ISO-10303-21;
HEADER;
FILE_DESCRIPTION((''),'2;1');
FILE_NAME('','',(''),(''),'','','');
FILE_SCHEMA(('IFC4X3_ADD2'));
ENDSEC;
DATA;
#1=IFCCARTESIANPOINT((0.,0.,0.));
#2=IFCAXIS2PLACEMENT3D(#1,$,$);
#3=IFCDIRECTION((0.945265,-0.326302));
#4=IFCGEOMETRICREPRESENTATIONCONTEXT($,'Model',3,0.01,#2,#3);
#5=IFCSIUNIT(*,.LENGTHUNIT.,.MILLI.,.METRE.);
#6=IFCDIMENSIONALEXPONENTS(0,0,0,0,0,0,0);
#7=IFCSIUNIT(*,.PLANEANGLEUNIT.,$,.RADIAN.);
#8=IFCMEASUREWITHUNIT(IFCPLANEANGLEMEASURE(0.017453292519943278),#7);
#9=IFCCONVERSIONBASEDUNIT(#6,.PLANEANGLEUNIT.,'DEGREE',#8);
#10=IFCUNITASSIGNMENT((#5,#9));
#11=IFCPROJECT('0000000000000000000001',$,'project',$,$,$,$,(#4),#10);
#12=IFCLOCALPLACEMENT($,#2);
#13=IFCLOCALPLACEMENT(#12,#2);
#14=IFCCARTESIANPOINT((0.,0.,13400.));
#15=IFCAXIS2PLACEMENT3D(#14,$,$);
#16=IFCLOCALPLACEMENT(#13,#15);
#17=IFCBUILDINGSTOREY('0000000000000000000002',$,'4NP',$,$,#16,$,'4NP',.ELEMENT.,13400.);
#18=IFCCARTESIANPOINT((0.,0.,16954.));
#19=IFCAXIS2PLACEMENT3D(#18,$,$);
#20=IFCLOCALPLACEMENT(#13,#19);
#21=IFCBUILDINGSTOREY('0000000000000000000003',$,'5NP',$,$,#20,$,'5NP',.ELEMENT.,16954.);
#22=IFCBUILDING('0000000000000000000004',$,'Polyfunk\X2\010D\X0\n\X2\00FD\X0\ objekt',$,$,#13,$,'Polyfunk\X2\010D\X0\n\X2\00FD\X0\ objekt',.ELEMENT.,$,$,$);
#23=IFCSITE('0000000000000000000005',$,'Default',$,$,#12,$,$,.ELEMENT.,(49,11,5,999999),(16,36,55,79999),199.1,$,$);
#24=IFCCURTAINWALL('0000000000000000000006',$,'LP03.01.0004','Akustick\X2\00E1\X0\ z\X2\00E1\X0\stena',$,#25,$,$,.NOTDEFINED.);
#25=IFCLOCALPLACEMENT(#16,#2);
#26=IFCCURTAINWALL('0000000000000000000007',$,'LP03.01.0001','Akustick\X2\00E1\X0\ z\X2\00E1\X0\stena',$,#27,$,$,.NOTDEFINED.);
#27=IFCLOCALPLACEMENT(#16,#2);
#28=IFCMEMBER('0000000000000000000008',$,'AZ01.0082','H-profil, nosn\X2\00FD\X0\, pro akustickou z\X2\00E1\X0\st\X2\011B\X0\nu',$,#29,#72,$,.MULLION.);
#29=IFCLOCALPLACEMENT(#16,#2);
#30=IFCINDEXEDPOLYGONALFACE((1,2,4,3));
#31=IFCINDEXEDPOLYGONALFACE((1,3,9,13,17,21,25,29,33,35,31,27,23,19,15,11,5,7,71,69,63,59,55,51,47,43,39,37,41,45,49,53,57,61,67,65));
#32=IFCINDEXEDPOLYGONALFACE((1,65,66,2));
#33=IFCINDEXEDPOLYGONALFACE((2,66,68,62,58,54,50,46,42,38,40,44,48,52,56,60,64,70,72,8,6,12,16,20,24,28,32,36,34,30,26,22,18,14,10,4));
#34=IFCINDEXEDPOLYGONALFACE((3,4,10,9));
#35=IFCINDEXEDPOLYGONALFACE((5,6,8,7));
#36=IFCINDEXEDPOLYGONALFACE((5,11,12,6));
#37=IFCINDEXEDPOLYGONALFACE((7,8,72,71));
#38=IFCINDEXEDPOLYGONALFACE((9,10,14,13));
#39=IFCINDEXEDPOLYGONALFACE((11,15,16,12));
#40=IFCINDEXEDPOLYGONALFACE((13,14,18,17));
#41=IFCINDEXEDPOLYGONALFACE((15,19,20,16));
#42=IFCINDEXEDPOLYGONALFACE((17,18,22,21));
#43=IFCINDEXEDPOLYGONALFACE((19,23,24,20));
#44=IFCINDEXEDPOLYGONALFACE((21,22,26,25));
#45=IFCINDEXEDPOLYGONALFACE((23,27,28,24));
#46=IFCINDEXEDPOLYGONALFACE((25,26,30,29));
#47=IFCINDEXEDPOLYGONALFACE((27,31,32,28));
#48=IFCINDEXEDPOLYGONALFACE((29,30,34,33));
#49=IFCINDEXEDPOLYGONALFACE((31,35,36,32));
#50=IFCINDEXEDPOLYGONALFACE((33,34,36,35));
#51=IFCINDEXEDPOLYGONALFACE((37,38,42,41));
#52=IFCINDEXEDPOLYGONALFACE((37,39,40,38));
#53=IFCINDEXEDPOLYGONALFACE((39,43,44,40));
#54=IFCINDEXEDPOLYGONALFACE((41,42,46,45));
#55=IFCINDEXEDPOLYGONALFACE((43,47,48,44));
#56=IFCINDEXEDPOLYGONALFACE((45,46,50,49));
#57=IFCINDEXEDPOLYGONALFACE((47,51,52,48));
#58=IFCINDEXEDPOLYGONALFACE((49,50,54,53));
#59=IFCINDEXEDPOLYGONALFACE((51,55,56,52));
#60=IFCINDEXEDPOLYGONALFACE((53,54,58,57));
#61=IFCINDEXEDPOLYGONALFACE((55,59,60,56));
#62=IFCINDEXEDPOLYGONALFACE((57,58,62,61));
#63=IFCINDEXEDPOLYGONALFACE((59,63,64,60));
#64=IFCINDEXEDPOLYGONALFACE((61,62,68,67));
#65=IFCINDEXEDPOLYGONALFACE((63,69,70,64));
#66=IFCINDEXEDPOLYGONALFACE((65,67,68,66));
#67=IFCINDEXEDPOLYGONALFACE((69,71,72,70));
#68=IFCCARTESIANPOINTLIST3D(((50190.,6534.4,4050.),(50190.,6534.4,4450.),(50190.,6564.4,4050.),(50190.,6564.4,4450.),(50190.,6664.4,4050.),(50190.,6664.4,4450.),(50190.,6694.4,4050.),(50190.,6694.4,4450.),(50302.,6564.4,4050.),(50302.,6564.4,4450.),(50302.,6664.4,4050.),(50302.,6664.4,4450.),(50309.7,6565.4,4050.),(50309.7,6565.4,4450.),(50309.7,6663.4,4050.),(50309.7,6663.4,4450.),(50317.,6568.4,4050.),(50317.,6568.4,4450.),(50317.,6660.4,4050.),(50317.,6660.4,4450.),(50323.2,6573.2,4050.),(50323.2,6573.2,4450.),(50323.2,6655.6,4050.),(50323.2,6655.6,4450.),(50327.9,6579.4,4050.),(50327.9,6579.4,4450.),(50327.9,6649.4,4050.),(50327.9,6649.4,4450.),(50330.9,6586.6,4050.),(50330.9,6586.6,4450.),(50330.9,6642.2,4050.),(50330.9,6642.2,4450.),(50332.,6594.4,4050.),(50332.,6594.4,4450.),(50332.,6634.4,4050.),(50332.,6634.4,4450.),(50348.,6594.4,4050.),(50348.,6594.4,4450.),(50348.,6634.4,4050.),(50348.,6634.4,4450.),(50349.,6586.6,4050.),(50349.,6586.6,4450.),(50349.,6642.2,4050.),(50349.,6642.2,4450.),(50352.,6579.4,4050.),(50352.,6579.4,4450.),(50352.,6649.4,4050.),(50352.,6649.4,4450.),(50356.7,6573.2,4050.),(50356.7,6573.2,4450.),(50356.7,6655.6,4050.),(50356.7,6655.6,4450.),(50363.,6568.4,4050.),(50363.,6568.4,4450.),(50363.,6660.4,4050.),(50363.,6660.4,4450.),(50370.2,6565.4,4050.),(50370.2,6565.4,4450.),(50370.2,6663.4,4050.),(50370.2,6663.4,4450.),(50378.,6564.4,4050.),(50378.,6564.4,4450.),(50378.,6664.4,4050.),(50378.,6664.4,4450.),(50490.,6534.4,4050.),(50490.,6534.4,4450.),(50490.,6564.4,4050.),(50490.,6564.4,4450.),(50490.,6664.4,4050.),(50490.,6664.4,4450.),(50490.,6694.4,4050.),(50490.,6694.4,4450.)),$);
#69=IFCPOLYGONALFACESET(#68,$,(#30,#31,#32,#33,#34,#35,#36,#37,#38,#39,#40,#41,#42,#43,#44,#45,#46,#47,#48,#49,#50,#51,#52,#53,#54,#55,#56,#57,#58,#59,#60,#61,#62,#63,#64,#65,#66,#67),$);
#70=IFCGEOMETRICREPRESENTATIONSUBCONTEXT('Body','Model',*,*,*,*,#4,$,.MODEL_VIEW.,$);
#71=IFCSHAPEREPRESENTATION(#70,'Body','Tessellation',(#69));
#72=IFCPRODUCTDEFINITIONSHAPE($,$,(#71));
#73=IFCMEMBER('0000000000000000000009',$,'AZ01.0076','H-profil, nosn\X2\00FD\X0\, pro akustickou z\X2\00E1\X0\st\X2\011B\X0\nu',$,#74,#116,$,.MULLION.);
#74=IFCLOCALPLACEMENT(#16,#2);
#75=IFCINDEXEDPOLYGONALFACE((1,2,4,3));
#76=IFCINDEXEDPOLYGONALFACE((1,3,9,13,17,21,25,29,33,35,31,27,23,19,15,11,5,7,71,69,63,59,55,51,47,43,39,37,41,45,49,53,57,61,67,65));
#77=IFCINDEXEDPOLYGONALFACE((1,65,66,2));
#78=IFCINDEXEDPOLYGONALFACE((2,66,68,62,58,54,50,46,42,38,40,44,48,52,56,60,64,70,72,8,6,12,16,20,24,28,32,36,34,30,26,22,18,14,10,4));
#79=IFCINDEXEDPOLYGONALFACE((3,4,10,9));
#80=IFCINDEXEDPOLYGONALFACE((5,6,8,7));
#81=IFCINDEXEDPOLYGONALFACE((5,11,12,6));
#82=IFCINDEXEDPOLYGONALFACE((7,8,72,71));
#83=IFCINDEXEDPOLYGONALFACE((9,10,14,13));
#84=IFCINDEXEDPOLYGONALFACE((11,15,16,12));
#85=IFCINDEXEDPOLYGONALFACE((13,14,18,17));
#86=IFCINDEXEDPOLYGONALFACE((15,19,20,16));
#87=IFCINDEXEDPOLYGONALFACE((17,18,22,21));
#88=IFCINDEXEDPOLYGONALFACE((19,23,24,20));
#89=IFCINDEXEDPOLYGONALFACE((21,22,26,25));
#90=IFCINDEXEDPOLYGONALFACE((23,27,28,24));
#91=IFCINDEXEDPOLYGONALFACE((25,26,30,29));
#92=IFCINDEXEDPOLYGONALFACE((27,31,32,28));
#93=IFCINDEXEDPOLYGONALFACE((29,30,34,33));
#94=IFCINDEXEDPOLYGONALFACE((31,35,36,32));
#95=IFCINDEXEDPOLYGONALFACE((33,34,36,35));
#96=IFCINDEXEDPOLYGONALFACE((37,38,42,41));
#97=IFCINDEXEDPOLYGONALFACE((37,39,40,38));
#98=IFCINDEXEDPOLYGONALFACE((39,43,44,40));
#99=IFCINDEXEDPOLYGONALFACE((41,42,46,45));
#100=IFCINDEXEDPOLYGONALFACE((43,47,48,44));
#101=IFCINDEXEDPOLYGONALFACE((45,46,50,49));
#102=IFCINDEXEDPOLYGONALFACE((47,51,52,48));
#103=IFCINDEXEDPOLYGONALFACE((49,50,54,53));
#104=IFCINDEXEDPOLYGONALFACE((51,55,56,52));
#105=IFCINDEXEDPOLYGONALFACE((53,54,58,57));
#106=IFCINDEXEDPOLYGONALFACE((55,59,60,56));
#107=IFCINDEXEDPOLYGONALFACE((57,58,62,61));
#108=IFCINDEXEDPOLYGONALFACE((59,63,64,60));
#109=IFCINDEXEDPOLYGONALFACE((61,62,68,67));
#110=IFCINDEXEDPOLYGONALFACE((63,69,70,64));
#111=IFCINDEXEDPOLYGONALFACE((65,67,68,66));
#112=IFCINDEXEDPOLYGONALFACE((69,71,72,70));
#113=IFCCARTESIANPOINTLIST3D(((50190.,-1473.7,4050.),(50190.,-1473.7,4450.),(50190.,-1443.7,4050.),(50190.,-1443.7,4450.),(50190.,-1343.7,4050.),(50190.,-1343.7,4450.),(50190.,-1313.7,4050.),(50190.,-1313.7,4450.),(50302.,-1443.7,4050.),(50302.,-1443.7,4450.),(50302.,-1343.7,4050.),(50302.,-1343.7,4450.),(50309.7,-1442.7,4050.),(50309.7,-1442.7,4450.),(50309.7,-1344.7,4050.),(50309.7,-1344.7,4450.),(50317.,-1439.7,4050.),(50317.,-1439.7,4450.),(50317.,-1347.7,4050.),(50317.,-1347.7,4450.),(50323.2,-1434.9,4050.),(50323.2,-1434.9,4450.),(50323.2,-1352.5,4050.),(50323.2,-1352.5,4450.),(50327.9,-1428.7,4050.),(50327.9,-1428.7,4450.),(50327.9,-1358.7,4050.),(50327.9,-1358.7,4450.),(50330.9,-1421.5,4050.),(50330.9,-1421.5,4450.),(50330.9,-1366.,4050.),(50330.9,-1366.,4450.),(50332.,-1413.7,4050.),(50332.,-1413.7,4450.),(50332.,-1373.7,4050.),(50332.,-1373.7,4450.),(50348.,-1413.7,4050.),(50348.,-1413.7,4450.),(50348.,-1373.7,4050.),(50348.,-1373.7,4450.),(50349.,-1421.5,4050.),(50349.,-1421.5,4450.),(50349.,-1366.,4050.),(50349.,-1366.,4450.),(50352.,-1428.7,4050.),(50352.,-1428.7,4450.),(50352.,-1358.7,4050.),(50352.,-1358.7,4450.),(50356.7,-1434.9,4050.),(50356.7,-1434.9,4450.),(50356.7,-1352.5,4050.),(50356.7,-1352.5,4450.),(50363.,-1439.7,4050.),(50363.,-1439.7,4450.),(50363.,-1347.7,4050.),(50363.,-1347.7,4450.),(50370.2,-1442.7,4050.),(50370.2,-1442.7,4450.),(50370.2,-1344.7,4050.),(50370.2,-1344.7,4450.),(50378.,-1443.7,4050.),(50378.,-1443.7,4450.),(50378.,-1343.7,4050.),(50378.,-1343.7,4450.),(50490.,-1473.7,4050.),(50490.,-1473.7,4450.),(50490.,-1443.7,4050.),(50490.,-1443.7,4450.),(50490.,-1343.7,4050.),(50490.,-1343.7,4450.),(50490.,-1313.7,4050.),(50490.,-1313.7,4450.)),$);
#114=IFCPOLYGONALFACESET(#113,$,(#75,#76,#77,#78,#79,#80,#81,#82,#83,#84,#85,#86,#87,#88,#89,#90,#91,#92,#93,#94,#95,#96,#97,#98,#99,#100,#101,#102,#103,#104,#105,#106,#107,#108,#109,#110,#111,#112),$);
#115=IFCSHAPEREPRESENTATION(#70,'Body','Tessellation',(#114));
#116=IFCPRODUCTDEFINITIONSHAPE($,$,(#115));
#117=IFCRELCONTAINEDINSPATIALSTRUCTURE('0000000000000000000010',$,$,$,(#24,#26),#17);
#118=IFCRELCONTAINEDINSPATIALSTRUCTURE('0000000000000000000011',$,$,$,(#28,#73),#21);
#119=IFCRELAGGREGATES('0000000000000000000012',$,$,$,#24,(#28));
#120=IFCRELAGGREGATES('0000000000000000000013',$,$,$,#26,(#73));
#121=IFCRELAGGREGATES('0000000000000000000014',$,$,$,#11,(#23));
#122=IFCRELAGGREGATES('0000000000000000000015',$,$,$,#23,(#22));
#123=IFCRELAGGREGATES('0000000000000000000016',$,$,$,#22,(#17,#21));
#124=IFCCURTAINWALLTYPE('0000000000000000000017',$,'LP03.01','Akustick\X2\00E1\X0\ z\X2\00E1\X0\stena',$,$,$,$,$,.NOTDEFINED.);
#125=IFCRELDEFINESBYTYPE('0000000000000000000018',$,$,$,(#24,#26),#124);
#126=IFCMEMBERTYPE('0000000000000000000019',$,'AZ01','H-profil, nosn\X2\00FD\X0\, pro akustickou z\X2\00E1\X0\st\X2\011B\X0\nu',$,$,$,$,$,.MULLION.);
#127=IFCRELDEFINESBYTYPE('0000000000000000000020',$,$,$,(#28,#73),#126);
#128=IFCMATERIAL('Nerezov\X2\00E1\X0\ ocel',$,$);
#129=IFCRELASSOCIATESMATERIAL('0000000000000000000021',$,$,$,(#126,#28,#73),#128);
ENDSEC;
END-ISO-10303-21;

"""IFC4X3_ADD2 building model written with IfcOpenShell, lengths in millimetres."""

from ifc_helpers import new_model, entity, si_unit, converted_unit, direction, frame, frame_2d, origin, place, context, subcontext, project, spatial, polyline, circle_curve, parameter, trimmed, segment, composite_curve, outline, extrude, source, transform, mapped, material, material_profile, profile_set, profile_usage, type_object, element, aggregate, save


model = new_model("IFC4X3_ADD2")

# Units and contexts
model_context = context("Model", 3, precision=0.01, world=origin(), true_north=direction((0.945265, -0.326302)))
body_context = subcontext(model_context, "Body", "Model", "MODEL_VIEW")
ifc_project = project(units=[si_unit("LENGTHUNIT", "METRE", prefix="MILLI"), converted_unit("PLANEANGLEUNIT", "DEGREE", entity("IfcPlaneAngleMeasure", 0.017453292519943278), si_unit("PLANEANGLEUNIT", "RADIAN"), dimensions=[0, 0, 0, 0, 0, 0, 0])], contexts=[model_context])

# Site, building, storey
site_placement = place(None, origin())
site = spatial("IfcSite", under=ifc_project, at=site_placement, Name="Default", CompositionType="ELEMENT", RefLatitude=(49, 11, 5, 999999), RefLongitude=(16, 36, 55, 79999), RefElevation=199.1)
building_placement = place(site_placement, origin())
building = spatial("IfcBuilding", under=site, at=building_placement, Name="Polyfunkčný objekt", LongName="Polyfunkčný objekt", CompositionType="ELEMENT")
storey_1_placement = place(building_placement, frame((0.0, 0.0, 13400.0)))
storey_1 = spatial("IfcBuildingStorey", under=building, at=storey_1_placement, Name="4NP", LongName="4NP", CompositionType="ELEMENT", Elevation=13400.0)

# Curtain wall
curtain_wall_type = type_object("IfcCurtainWallType", Name="LP03.01", Description="Akustická zástena", PredefinedType="NOTDEFINED")
curtain_wall_1_placement = place(storey_1_placement, frame((0.0, 0.0, -13400.0)))
curtain_wall_1 = element("IfcCurtainWall", 1, at=curtain_wall_1_placement, inside=storey_1, type_object=curtain_wall_type, Name="LP03.01.0004", Description="Akustická zástena", PredefinedType="NOTDEFINED")

# Shared definitions
storey_2_placement = place(building_placement, frame((0.0, 0.0, 16954.0)))
storey_2 = spatial("IfcBuildingStorey", under=building, at=storey_2_placement, Name="5NP", LongName="5NP", CompositionType="ELEMENT", Elevation=16954.0)

# Shared definitions
ifc_material_1 = material(Name="Nerezová ocel")
ifc_material_profile = material_profile(ifc_material_1, outline(composite_curve([segment(polyline([(50.0, -150.0), (80.0, -150.0)]), True, "CONTINUOUS"), segment(polyline([(80.0, -150.0), (80.0, 150.0)]), True, "CONTINUOUS"), segment(polyline([(80.0, 150.0), (50.0, 150.0)]), True, "CONTINUOUS"), segment(polyline([(50.0, 150.0), (50.0, 38.0)]), True, "CONTINUOUS"), segment(trimmed(circle_curve(frame_2d((20.0, 38.0), x_axis=(0.0, 1.0)), 30.0), [parameter(180.0)], [parameter(270.0)], True, "PARAMETER"), False, "CONTINUOUS"), segment(polyline([(20.0, 8.0), (-20.0, 8.0)]), True, "CONTINUOUS"), segment(trimmed(circle_curve(frame_2d((-20.0, 38.0), x_axis=(0.0, 1.0)), 30.0), [parameter(90.0)], [parameter(180.0)], True, "PARAMETER"), False, "CONTINUOUS"), segment(polyline([(-50.0, 38.0), (-50.0, 150.0)]), True, "CONTINUOUS"), segment(polyline([(-50.0, 150.0), (-80.0, 150.0)]), True, "CONTINUOUS"), segment(polyline([(-80.0, 150.0), (-80.0, -150.0)]), True, "CONTINUOUS"), segment(polyline([(-80.0, -150.0), (-50.0, -150.0)]), True, "CONTINUOUS"), segment(polyline([(-50.0, -150.0), (-50.0, -38.0)]), True, "CONTINUOUS"), segment(trimmed(circle_curve(frame_2d((-20.0, -38.0), x_axis=(0.0, 1.0)), 30.0), [parameter(0.0)], [parameter(90.0)], True, "PARAMETER"), False, "CONTINUOUS"), segment(polyline([(-20.0, -8.0), (20.0, -8.0)]), True, "CONTINUOUS"), segment(trimmed(circle_curve(frame_2d((20.0, -38.0), x_axis=(0.0, 1.0)), 30.0), [parameter(270.0)], [parameter(0.0)], True, "PARAMETER"), False, "CONTINUOUS"), segment(polyline([(50.0, -38.0), (50.0, -150.0)]), True, "CONTINUOUS")], self_intersect=False)), Name="Profil zástena")
ifc_profile_set = profile_set([ifc_material_profile], Name="Profil zástena")
ifc_profile_usage = profile_usage(ifc_profile_set)
member_type = type_object("IfcMemberType", Name="AZ01", Description="H-profil, nosný, pro akustickou zástěnu", PredefinedType="MULLION", material=ifc_profile_set)

# Curtain wall
curtain_wall_2_placement = place(storey_1_placement, frame((0.0, 0.0, -13400.0)))
curtain_wall_2 = element("IfcCurtainWall", 2, at=curtain_wall_2_placement, inside=storey_1, type_object=curtain_wall_type, Name="LP03.01.0001", Description="Akustická zástena", PredefinedType="NOTDEFINED")

# Members
shared_shape_1 = source(origin(), body_context, "Body", "SweptSolid", [
    extrude(outline(composite_curve([segment(polyline([(-150.0, -50.0), (-150.0, -80.0)]), True, "CONTINUOUS"), segment(polyline([(-150.0, -80.0), (150.0, -80.0)]), True, "CONTINUOUS"), segment(polyline([(150.0, -80.0), (150.0, -50.0)]), True, "CONTINUOUS"), segment(polyline([(150.0, -50.0), (38.0, -50.0)]), True, "CONTINUOUS"), segment(trimmed(circle_curve(frame_2d((38.0, -20.0), x_axis=(1.0, 0.0)), 30.0), [parameter(180.0)], [parameter(270.0)], True, "PARAMETER"), False, "CONTINUOUS"), segment(polyline([(8.0, -20.0), (8.0, 20.0)]), True, "CONTINUOUS"), segment(trimmed(circle_curve(frame_2d((38.0, 20.0), x_axis=(1.0, 0.0)), 30.0), [parameter(90.0)], [parameter(180.0)], True, "PARAMETER"), False, "CONTINUOUS"), segment(polyline([(38.0, 50.0), (150.0, 50.0)]), True, "CONTINUOUS"), segment(polyline([(150.0, 50.0), (150.0, 80.0)]), True, "CONTINUOUS"), segment(polyline([(150.0, 80.0), (-150.0, 80.0)]), True, "CONTINUOUS"), segment(polyline([(-150.0, 80.0), (-150.0, 50.0)]), True, "CONTINUOUS"), segment(polyline([(-150.0, 50.0), (-38.0, 50.0)]), True, "CONTINUOUS"), segment(trimmed(circle_curve(frame_2d((-38.0, 20.0), x_axis=(1.0, 0.0)), 30.0), [parameter(0.0)], [parameter(90.0)], True, "PARAMETER"), False, "CONTINUOUS"), segment(polyline([(-8.0, 20.0), (-8.0, -20.0)]), True, "CONTINUOUS"), segment(trimmed(circle_curve(frame_2d((-38.0, -20.0), x_axis=(1.0, 0.0)), 30.0), [parameter(270.0)], [parameter(0.0)], True, "PARAMETER"), False, "CONTINUOUS"), segment(polyline([(-38.0, -50.0), (-150.0, -50.0)]), True, "CONTINUOUS")], self_intersect=False)), frame((-150.0, 0.0, -400.0), z_axis=(0.0, 0.0, -1.0), x_axis=(-1.0, 0.0, 0.0)), (0.0, 0.0, -1.0), 400.0),
])
member_1_placement = place(curtain_wall_1_placement, frame((50190.0, 6614.4, 17850.0), z_axis=(0.0, 0.0, 1.0), x_axis=(-1.0, 0.0, 0.0)))
member_1 = element("IfcMember", 3, at=member_1_placement, inside=storey_2, type_object=member_type, material=ifc_profile_usage, Name="AZ01.0082", Description="H-profil, nosný, pro akustickou zástěnu", PredefinedType="MULLION", context=body_context, shape_type="MappedRepresentation", body=[
    mapped(shared_shape_1, transform((0.0, 0.0, 0.0), scale=1.0)),
])
member_2_placement = place(curtain_wall_2_placement, frame((50190.0, -1393.7, 17850.0), z_axis=(0.0, 0.0, 1.0), x_axis=(-1.0, 0.0, 0.0)))
member_2 = element("IfcMember", 4, at=member_2_placement, inside=storey_2, type_object=member_type, material=ifc_profile_usage, Name="AZ01.0076", Description="H-profil, nosný, pro akustickou zástěnu", PredefinedType="MULLION", context=body_context, shape_type="MappedRepresentation", body=[
    mapped(shared_shape_1, transform((0.0, 0.0, 0.0), scale=1.0)),
])

aggregate(curtain_wall_1, [member_1])
aggregate(curtain_wall_2, [member_2])

save(model, "model.ifc")
